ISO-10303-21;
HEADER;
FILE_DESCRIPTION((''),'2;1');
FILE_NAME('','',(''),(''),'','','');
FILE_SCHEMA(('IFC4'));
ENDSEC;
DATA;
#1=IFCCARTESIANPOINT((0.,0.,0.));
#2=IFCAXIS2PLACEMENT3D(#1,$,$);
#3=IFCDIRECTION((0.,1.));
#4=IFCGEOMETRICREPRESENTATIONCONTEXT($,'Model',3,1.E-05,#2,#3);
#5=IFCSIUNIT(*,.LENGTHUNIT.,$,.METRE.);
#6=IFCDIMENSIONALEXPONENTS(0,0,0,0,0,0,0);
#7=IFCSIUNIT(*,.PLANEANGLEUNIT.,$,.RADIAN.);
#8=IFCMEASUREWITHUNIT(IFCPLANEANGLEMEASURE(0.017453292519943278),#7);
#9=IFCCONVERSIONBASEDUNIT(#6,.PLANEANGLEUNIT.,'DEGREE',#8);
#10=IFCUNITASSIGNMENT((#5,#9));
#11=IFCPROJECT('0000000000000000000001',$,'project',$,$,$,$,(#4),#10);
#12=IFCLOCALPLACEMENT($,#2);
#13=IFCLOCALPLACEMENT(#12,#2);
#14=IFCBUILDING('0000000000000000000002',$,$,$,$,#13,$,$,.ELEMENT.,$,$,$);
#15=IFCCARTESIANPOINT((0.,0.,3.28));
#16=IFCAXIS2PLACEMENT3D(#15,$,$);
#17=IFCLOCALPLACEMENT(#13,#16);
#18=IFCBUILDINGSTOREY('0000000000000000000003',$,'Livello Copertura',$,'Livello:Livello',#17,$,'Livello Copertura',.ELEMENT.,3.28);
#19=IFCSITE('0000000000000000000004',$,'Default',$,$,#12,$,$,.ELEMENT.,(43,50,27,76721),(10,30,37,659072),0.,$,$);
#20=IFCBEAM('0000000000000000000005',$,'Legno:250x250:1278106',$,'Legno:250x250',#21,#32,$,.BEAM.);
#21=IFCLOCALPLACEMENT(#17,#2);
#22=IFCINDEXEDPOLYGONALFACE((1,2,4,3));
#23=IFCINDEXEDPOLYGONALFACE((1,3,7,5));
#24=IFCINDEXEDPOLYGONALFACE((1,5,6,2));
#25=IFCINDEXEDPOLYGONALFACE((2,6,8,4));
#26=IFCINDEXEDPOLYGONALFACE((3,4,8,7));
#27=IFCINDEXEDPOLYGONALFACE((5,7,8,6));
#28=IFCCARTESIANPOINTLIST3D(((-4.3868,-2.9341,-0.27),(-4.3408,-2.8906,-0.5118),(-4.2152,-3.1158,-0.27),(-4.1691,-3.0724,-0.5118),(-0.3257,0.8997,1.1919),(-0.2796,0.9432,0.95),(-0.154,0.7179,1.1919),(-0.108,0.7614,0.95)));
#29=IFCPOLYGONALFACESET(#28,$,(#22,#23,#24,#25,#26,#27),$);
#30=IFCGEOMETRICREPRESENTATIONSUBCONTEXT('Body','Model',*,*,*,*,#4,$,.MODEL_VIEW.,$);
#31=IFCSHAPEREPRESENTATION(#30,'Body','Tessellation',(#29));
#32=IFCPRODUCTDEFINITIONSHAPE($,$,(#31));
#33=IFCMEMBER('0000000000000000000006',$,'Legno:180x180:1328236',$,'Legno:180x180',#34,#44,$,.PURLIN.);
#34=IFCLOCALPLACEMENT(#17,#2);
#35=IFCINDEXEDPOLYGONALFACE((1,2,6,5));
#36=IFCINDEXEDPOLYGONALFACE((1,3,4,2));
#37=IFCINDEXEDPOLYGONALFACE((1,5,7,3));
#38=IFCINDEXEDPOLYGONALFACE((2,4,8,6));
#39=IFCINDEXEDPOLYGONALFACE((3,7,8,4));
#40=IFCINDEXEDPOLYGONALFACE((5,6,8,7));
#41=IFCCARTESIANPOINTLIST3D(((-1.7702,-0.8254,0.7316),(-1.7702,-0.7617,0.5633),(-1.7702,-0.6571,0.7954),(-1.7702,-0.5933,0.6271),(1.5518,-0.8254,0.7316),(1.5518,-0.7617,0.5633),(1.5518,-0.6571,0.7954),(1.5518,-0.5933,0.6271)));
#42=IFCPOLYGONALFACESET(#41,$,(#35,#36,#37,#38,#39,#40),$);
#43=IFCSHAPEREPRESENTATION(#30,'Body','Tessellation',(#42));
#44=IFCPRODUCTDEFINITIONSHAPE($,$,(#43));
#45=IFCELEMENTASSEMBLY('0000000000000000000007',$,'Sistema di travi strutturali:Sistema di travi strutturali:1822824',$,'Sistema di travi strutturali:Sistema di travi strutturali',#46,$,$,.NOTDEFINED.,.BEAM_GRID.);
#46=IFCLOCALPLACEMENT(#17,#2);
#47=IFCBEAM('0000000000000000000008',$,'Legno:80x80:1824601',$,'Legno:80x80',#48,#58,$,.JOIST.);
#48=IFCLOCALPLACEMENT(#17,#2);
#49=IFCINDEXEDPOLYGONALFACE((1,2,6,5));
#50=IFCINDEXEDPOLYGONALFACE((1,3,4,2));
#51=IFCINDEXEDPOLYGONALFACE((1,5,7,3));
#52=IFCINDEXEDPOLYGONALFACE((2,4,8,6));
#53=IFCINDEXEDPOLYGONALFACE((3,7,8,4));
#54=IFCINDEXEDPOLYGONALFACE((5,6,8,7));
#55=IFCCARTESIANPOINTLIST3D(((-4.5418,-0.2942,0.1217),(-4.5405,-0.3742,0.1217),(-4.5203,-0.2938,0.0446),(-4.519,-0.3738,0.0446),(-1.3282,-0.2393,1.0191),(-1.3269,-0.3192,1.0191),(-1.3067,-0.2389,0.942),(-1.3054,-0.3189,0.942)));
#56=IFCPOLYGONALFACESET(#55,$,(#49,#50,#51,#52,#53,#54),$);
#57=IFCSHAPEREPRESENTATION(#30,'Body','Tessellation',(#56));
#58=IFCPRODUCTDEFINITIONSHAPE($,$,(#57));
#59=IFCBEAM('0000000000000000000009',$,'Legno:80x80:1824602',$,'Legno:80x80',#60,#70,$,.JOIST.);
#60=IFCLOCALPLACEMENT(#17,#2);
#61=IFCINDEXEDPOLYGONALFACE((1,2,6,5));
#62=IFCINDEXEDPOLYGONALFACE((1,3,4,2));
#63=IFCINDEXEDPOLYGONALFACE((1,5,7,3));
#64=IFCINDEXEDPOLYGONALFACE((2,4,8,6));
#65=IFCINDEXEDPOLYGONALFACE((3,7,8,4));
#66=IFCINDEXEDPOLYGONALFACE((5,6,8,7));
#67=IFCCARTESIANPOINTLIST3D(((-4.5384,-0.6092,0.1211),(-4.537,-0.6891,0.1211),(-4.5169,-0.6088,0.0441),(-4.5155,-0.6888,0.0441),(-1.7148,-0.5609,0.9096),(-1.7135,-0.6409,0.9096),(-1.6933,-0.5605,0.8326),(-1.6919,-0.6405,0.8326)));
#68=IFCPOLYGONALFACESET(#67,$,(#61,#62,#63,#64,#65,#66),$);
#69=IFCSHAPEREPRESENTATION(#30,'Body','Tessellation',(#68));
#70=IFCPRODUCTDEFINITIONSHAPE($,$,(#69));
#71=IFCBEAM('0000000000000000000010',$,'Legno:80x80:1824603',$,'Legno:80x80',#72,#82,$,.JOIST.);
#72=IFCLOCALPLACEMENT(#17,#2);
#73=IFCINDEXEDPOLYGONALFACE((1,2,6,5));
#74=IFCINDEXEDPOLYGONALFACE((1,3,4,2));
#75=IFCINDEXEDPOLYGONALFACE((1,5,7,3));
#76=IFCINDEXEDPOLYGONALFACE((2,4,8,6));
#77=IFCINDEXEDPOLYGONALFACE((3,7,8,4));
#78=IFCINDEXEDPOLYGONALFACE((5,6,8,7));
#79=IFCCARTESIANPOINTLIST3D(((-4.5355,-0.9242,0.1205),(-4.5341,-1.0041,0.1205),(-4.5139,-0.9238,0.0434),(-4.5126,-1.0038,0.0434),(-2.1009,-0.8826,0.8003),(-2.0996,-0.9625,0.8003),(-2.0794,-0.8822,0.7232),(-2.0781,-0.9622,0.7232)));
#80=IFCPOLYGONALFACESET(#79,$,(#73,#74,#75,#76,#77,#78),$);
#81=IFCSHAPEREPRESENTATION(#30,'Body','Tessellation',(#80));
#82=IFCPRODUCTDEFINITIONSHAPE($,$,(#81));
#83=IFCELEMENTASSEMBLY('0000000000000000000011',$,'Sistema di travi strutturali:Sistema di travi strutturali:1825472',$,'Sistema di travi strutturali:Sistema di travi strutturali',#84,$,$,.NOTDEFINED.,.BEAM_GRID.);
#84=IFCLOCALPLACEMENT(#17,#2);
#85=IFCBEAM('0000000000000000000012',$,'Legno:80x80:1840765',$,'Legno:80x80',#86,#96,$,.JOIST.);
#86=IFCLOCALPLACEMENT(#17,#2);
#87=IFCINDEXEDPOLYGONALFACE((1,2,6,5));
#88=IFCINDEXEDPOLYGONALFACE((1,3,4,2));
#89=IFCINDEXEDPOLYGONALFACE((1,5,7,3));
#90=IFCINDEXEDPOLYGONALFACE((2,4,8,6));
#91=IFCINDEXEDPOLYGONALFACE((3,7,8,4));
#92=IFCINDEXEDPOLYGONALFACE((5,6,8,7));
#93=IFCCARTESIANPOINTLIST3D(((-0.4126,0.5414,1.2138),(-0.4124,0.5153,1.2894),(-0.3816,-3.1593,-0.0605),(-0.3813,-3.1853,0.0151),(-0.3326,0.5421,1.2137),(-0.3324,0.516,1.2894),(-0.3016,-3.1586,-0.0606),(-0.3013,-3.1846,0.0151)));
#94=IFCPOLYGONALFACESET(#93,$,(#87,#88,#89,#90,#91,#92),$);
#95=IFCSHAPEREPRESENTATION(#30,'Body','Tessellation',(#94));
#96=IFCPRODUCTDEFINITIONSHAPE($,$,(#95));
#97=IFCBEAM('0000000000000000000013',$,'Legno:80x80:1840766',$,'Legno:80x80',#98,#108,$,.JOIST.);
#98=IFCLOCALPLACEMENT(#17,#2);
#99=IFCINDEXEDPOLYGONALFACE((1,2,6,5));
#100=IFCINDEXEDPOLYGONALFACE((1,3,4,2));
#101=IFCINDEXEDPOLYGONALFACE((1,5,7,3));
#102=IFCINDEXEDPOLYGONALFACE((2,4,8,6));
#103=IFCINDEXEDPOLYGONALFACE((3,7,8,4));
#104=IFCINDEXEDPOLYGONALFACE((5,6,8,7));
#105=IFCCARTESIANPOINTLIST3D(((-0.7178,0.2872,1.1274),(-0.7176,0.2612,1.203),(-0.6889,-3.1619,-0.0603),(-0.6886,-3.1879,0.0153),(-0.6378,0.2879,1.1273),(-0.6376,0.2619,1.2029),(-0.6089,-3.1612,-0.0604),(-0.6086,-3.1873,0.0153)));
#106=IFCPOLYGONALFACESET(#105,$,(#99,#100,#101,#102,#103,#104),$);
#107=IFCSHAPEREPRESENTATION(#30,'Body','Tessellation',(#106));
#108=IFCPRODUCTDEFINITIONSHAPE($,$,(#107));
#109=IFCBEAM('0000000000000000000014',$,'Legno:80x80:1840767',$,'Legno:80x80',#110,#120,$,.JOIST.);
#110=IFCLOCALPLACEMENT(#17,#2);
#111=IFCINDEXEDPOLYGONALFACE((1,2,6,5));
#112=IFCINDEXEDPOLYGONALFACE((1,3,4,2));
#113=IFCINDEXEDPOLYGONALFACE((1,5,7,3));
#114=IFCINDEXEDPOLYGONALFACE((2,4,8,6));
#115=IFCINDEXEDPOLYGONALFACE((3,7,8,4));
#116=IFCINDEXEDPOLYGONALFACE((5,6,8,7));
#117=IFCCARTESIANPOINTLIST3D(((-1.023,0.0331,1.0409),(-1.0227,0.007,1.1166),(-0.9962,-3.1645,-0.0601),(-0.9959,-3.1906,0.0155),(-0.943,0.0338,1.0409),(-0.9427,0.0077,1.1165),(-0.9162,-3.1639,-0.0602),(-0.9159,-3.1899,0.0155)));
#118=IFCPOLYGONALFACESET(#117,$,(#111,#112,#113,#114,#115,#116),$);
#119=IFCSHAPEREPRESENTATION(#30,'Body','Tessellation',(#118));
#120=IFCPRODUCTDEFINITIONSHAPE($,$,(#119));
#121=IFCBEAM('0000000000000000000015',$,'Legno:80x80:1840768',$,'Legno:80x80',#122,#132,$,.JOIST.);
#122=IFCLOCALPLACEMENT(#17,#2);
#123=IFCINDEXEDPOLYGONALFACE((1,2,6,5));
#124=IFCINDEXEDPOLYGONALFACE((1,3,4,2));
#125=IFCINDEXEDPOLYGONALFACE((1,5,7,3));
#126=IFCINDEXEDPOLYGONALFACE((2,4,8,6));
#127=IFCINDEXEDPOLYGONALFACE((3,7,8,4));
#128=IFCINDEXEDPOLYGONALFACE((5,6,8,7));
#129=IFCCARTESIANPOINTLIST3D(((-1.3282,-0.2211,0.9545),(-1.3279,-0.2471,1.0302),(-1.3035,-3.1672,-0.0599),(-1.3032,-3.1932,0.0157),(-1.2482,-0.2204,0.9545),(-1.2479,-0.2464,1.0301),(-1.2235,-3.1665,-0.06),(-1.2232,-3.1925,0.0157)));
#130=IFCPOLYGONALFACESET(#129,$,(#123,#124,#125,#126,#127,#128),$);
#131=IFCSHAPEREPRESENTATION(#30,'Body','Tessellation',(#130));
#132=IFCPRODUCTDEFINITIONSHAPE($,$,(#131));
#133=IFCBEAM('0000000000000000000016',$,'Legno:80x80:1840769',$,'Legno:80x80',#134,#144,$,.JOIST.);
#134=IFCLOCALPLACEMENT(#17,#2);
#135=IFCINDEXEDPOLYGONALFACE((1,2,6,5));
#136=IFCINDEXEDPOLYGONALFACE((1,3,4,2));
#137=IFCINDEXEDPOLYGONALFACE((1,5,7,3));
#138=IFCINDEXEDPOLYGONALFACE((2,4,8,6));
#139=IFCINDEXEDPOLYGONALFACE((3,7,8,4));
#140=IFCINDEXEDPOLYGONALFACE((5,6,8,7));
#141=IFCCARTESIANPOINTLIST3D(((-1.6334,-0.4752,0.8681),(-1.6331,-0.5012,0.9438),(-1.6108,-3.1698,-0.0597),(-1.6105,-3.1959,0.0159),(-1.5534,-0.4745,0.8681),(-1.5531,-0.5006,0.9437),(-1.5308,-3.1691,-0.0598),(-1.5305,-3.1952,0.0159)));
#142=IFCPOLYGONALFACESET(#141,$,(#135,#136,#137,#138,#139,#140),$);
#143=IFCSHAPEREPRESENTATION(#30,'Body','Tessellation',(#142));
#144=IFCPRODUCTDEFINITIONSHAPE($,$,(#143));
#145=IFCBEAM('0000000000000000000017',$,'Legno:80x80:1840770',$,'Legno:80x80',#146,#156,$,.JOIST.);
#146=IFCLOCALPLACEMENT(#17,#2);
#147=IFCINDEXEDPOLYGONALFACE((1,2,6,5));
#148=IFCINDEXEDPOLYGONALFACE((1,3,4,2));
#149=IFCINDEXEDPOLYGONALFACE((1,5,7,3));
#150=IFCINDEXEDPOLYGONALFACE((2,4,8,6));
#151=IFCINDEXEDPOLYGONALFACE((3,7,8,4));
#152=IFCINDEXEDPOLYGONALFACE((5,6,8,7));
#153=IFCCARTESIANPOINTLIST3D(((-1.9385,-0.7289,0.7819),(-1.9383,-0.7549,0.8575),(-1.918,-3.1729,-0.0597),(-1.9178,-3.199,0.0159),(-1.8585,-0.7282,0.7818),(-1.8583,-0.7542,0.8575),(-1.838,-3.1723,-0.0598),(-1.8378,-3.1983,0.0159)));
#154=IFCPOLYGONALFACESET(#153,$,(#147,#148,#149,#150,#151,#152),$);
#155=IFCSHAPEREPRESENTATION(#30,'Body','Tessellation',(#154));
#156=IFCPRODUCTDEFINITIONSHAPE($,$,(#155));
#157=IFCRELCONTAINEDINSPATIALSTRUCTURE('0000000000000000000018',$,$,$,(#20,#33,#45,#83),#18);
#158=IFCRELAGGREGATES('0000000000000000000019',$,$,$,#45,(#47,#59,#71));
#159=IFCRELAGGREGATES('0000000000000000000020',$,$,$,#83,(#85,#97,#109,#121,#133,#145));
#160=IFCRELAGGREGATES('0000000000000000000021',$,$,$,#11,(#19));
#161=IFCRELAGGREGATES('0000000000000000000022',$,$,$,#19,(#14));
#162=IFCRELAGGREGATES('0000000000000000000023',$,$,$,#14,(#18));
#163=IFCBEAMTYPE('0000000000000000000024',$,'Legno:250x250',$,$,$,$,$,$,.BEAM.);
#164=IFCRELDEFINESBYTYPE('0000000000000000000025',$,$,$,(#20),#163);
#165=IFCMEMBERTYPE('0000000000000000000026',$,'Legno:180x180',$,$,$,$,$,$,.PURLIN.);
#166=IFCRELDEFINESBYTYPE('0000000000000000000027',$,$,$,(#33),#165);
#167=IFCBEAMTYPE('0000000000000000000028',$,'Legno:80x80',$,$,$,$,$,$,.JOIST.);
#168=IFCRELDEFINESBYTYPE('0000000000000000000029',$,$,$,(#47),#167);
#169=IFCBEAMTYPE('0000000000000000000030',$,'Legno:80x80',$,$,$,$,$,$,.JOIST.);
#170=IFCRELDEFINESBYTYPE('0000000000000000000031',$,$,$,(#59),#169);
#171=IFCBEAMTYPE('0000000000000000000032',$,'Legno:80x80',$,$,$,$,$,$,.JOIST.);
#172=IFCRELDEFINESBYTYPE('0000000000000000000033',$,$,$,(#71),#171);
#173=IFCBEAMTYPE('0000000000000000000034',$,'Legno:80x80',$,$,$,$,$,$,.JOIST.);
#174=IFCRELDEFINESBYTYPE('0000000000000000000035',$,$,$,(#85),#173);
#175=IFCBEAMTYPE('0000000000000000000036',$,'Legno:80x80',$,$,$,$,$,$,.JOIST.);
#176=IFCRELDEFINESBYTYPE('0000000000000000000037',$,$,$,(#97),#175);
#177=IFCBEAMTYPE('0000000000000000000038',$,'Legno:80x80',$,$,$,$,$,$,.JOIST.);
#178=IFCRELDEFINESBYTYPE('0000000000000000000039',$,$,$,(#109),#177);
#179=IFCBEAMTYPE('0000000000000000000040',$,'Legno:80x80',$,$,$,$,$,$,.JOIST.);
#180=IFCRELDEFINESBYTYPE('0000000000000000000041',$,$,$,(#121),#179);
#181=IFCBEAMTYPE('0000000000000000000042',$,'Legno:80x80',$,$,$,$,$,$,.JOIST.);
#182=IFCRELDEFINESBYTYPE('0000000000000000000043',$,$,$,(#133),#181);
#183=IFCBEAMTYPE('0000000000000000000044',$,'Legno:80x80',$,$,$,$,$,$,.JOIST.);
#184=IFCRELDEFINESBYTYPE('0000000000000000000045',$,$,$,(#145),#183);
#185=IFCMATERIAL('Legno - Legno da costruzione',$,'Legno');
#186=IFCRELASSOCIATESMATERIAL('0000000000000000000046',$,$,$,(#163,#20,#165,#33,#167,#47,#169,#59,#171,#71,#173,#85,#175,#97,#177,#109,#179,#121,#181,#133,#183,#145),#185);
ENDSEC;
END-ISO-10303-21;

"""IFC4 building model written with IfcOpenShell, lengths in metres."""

from ifc_helpers import new_model, entity, si_unit, converted_unit, direction, frame, origin, place, context, subcontext, project, spatial, indexed_curve, outline, extrude, source, transform, mapped, material, type_object, type_shapes, element, aggregate, save


model = new_model("IFC4")

# Units and contexts
model_context = context("Model", 3, precision=1e-05, world=origin(), true_north=direction((0.0, 1.0)))
body_context = subcontext(model_context, "Body", "Model", "MODEL_VIEW")
ifc_project = project(units=[si_unit("LENGTHUNIT", "METRE"), converted_unit("PLANEANGLEUNIT", "DEGREE", entity("IfcPlaneAngleMeasure", 0.017453292519943278), si_unit("PLANEANGLEUNIT", "RADIAN"), dimensions=[0, 0, 0, 0, 0, 0, 0])], contexts=[model_context])

# Site, building, storey
site_placement = place(None, origin())
site = spatial("IfcSite", under=ifc_project, at=site_placement, Name="Default", CompositionType="ELEMENT", RefLatitude=(43, 50, 27, 76721), RefLongitude=(10, 30, 37, 659072), RefElevation=0.0)
building_placement = place(site_placement, origin())
building = spatial("IfcBuilding", under=site, at=building_placement, CompositionType="ELEMENT")
storey_placement = place(building_placement, frame((0.0, 0.0, 3.28)))
storey = spatial("IfcBuildingStorey", under=building, at=storey_placement, Name="Livello Copertura", ObjectType="Livello:Livello", LongName="Livello Copertura", CompositionType="ELEMENT", Elevation=3.28)

# Beam
ifc_material = material(Name="Legno - Legno da costruzione", Category="Legno")
beam_type_1 = type_object("IfcBeamType", Name="Legno:250x250", PredefinedType="BEAM", material=ifc_material)
shared_shape_1 = source(origin(), body_context, "Body", "SweptSolid", [
    extrude(outline(indexed_curve([(-2.8865, -0.125), (2.8865, -0.125), (2.8865, 0.125), (-2.8865, 0.125), (-2.8865, -0.125)], self_intersect=False)), frame((-0.093, 0.0, -0.125), z_axis=(0.0, 0.0, 1.0), x_axis=(-1.0, 0.0, 0.0)), (0.0, 0.0, 1.0), 0.25),
])
type_shapes(beam_type_1, [shared_shape_1])
beam_1_placement = place(storey_placement, frame((-2.182, -1.0246, 0.3636), z_axis=(-0.18413, -0.173822, 0.96741), x_axis=(0.703469, 0.664088, 0.253215)))
element("IfcBeam", 1, at=beam_1_placement, inside=storey, type_object=beam_type_1, material=ifc_material, Name="Legno:250x250:1278106", ObjectType="Legno:250x250", PredefinedType="BEAM", context=body_context, shape_type="MappedRepresentation", body=[
    mapped(shared_shape_1, transform((0.0, 0.0, 0.0), scale=1.0)),
])

# Member
member_type = type_object("IfcMemberType", Name="Legno:180x180", PredefinedType="PURLIN", material=ifc_material)
shared_shape_2 = source(origin(), body_context, "Body", "SweptSolid", [
    extrude(outline(indexed_curve([(-1.661, -0.09), (1.661, -0.09), (1.661, 0.09), (-1.661, 0.09), (-1.661, -0.09)], self_intersect=False)), frame((0.0, 0.0, -0.09), z_axis=(0.0, 0.0, 1.0), x_axis=(-1.0, 0.0, 0.0)), (0.0, 0.0, 1.0), 0.18),
])
type_shapes(member_type, [shared_shape_2])
member_placement = place(storey_placement, frame((-0.1092, -0.7094, 0.6793), z_axis=(0.0, -0.354291, 0.935135), x_axis=(1.0, 0.0, 0.0)))
element("IfcMember", 2, at=member_placement, inside=storey, type_object=member_type, material=ifc_material, Name="Legno:180x180:1328236", ObjectType="Legno:180x180", PredefinedType="PURLIN", context=body_context, shape_type="MappedRepresentation", body=[
    mapped(shared_shape_2, transform((0.0, 0.0, 0.0), scale=1.0)),
])

# Element assemblies, beams
assembly_1_placement = place(storey_placement, origin())
assembly_1 = element("IfcElementAssembly", 3, at=assembly_1_placement, inside=storey, Name="Sistema di travi strutturali:Sistema di travi strutturali:1822824", ObjectType="Sistema di travi strutturali:Sistema di travi strutturali", AssemblyPlace="NOTDEFINED", PredefinedType="BEAM_GRID")
beam_type_2 = type_object("IfcBeamType", Name="Legno:80x80", PredefinedType="JOIST", material=ifc_material)
shared_shape_3 = source(origin(), body_context, "Body", "SweptSolid", [
    extrude(outline(indexed_curve([(-1.6685, -0.04), (1.6685, -0.04), (1.6685, 0.04), (-1.6685, 0.04), (-1.6685, -0.04)], self_intersect=False)), frame((0.0, 0.0, -0.04), z_axis=(0.0, 0.0, 1.0), x_axis=(-1.0, 0.0, 0.0)), (0.0, 0.0, 1.0), 0.08),
])
type_shapes(beam_type_2, [shared_shape_3])
beam_2_placement = place(assembly_1_placement, frame((-2.9236, -0.3065, 0.5319), z_axis=(-0.268881, -0.004594, 0.963163), x_axis=(0.963022, 0.016456, 0.26892)))
beam_2 = element("IfcBeam", 4, at=beam_2_placement, type_object=beam_type_2, material=ifc_material, Name="Legno:80x80:1824601", ObjectType="Legno:80x80", PredefinedType="JOIST", context=body_context, shape_type="MappedRepresentation", body=[
    mapped(shared_shape_3, transform((0.0, 0.0, 0.0), scale=1.0)),
])
beam_type_3 = type_object("IfcBeamType", Name="Legno:80x80", PredefinedType="JOIST", material=ifc_material)
shared_shape_4 = source(origin(), body_context, "Body", "SweptSolid", [
    extrude(outline(indexed_curve([(-1.466, -0.04), (1.466, -0.04), (1.466, 0.04), (-1.466, 0.04), (-1.466, -0.04)], self_intersect=False)), frame((0.0, 0.0, -0.04), z_axis=(0.0, 0.0, 1.0), x_axis=(-1.0, 0.0, 0.0)), (0.0, 0.0, 1.0), 0.08),
])
type_shapes(beam_type_3, [shared_shape_4])
beam_3_placement = place(assembly_1_placement, frame((-3.1152, -0.6248, 0.4769), z_axis=(-0.268881, -0.004594, 0.963163), x_axis=(0.963022, 0.016456, 0.26892)))
beam_3 = element("IfcBeam", 5, at=beam_3_placement, type_object=beam_type_3, material=ifc_material, Name="Legno:80x80:1824602", ObjectType="Legno:80x80", PredefinedType="JOIST", context=body_context, shape_type="MappedRepresentation", body=[
    mapped(shared_shape_4, transform((0.0, 0.0, 0.0), scale=1.0)),
])
beam_type_4 = type_object("IfcBeamType", Name="Legno:80x80", PredefinedType="JOIST", material=ifc_material)
shared_shape_5 = source(origin(), body_context, "Body", "SweptSolid", [
    extrude(outline(indexed_curve([(-1.264, -0.04), (1.264, -0.04), (1.264, 0.04), (-1.264, 0.04), (-1.264, -0.04)], self_intersect=False)), frame((0.0, 0.0, -0.04), z_axis=(0.0, 0.0, 1.0), x_axis=(-1.0, 0.0, 0.0)), (0.0, 0.0, 1.0), 0.08),
])
type_shapes(beam_type_4, [shared_shape_5])
beam_4_placement = place(assembly_1_placement, frame((-3.3068, -0.9432, 0.4219), z_axis=(-0.268881, -0.004594, 0.963163), x_axis=(0.963022, 0.016456, 0.26892)))
beam_4 = element("IfcBeam", 6, at=beam_4_placement, type_object=beam_type_4, material=ifc_material, Name="Legno:80x80:1824603", ObjectType="Legno:80x80", PredefinedType="JOIST", context=body_context, shape_type="MappedRepresentation", body=[
    mapped(shared_shape_5, transform((0.0, 0.0, 0.0), scale=1.0)),
])
aggregate(assembly_1, [beam_2, beam_3, beam_4])
assembly_2_placement = place(storey_placement, origin())
assembly_2 = element("IfcElementAssembly", 7, at=assembly_2_placement, inside=storey, Name="Sistema di travi strutturali:Sistema di travi strutturali:1825472", ObjectType="Sistema di travi strutturali:Sistema di travi strutturali", AssemblyPlace="NOTDEFINED", PredefinedType="BEAM_GRID")
beam_type_5 = type_object("IfcBeamType", Name="Legno:80x80", PredefinedType="JOIST", material=ifc_material)
shared_shape_6 = source(origin(), body_context, "Body", "SweptSolid", [
    extrude(outline(indexed_curve([(-1.957, -0.04), (1.957, -0.04), (1.957, 0.04), (-1.957, 0.04), (-1.957, -0.04)], self_intersect=False)), frame((0.0, 0.0, -0.04), z_axis=(0.0, 0.0, 1.0), x_axis=(-1.0, 0.0, 0.0)), (0.0, 0.0, 1.0), 0.08),
])
type_shapes(beam_type_5, [shared_shape_6])
beam_5_placement = place(assembly_2_placement, frame((-0.357, -1.3216, 0.6144), z_axis=(0.003393, -0.32555, 0.945519), x_axis=(-0.007932, 0.945486, 0.325568)))
beam_5 = element("IfcBeam", 8, at=beam_5_placement, type_object=beam_type_5, material=ifc_material, Name="Legno:80x80:1840765", ObjectType="Legno:80x80", PredefinedType="JOIST", context=body_context, shape_type="MappedRepresentation", body=[
    mapped(shared_shape_6, transform((0.0, 0.0, 0.0), scale=1.0)),
])
beam_type_6 = type_object("IfcBeamType", Name="Legno:80x80", PredefinedType="JOIST", material=ifc_material)
shared_shape_7 = source(origin(), body_context, "Body", "SweptSolid", [
    extrude(outline(indexed_curve([(-1.824, -0.04), (1.824, -0.04), (1.824, 0.04), (-1.824, 0.04), (-1.824, -0.04)], self_intersect=False)), frame((0.0, 0.0, -0.04), z_axis=(0.0, 0.0, 1.0), x_axis=(-1.0, 0.0, 0.0)), (0.0, 0.0, 1.0), 0.08),
])
type_shapes(beam_type_6, [shared_shape_7])
beam_6_placement = place(assembly_2_placement, frame((-0.6632, -1.45, 0.5713), z_axis=(0.003393, -0.32555, 0.945519), x_axis=(-0.007932, 0.945486, 0.325568)))
beam_6 = element("IfcBeam", 9, at=beam_6_placement, type_object=beam_type_6, material=ifc_material, Name="Legno:80x80:1840766", ObjectType="Legno:80x80", PredefinedType="JOIST", context=body_context, shape_type="MappedRepresentation", body=[
    mapped(shared_shape_7, transform((0.0, 0.0, 0.0), scale=1.0)),
])
beam_type_7 = type_object("IfcBeamType", Name="Legno:80x80", PredefinedType="JOIST", material=ifc_material)
shared_shape_8 = source(origin(), body_context, "Body", "SweptSolid", [
    extrude(outline(indexed_curve([(-1.691, -0.04), (1.691, -0.04), (1.691, 0.04), (-1.691, 0.04), (-1.691, -0.04)], self_intersect=False)), frame((0.0, 0.0, -0.04), z_axis=(0.0, 0.0, 1.0), x_axis=(-1.0, 0.0, 0.0)), (0.0, 0.0, 1.0), 0.08),
])
type_shapes(beam_type_7, [shared_shape_8])
beam_7_placement = place(assembly_2_placement, frame((-0.9695, -1.5784, 0.5282), z_axis=(0.003393, -0.32555, 0.945519), x_axis=(-0.007932, 0.945486, 0.325568)))
beam_7 = element("IfcBeam", 10, at=beam_7_placement, type_object=beam_type_7, material=ifc_material, Name="Legno:80x80:1840767", ObjectType="Legno:80x80", PredefinedType="JOIST", context=body_context, shape_type="MappedRepresentation", body=[
    mapped(shared_shape_8, transform((0.0, 0.0, 0.0), scale=1.0)),
])
beam_type_8 = type_object("IfcBeamType", Name="Legno:80x80", PredefinedType="JOIST", material=ifc_material)
shared_shape_9 = source(origin(), body_context, "Body", "SweptSolid", [
    extrude(outline(indexed_curve([(-1.558, -0.04), (1.558, -0.04), (1.558, 0.04), (-1.558, 0.04), (-1.558, -0.04)], self_intersect=False)), frame((0.0, 0.0, -0.04), z_axis=(0.0, 0.0, 1.0), x_axis=(-1.0, 0.0, 0.0)), (0.0, 0.0, 1.0), 0.08),
])
type_shapes(beam_type_8, [shared_shape_9])
beam_8_placement = place(assembly_2_placement, frame((-1.2757, -1.7068, 0.4851), z_axis=(0.003393, -0.32555, 0.945519), x_axis=(-0.007932, 0.945486, 0.325568)))
beam_8 = element("IfcBeam", 11, at=beam_8_placement, type_object=beam_type_8, material=ifc_material, Name="Legno:80x80:1840768", ObjectType="Legno:80x80", PredefinedType="JOIST", context=body_context, shape_type="MappedRepresentation", body=[
    mapped(shared_shape_9, transform((0.0, 0.0, 0.0), scale=1.0)),
])
beam_type_9 = type_object("IfcBeamType", Name="Legno:80x80", PredefinedType="JOIST", material=ifc_material)
shared_shape_10 = source(origin(), body_context, "Body", "SweptSolid", [
    extrude(outline(indexed_curve([(-1.425, -0.04), (1.425, -0.04), (1.425, 0.04), (-1.425, 0.04), (-1.425, -0.04)], self_intersect=False)), frame((0.0, 0.0, -0.04), z_axis=(0.0, 0.0, 1.0), x_axis=(-1.0, 0.0, 0.0)), (0.0, 0.0, 1.0), 0.08),
])
type_shapes(beam_type_9, [shared_shape_10])
beam_9_placement = place(assembly_2_placement, frame((-1.5819, -1.8352, 0.442), z_axis=(0.003393, -0.32555, 0.945519), x_axis=(-0.007932, 0.945486, 0.325568)))
beam_9 = element("IfcBeam", 12, at=beam_9_placement, type_object=beam_type_9, material=ifc_material, Name="Legno:80x80:1840769", ObjectType="Legno:80x80", PredefinedType="JOIST", context=body_context, shape_type="MappedRepresentation", body=[
    mapped(shared_shape_10, transform((0.0, 0.0, 0.0), scale=1.0)),
])
beam_type_10 = type_object("IfcBeamType", Name="Legno:80x80", PredefinedType="JOIST", material=ifc_material)
shared_shape_11 = source(origin(), body_context, "Body", "SweptSolid", [
    extrude(outline(indexed_curve([(-1.2925, -0.04), (1.2925, -0.04), (1.2925, 0.04), (-1.2925, 0.04), (-1.2925, -0.04)], self_intersect=False)), frame((0.0, 0.0, -0.04), z_axis=(0.0, 0.0, 1.0), x_axis=(-1.0, 0.0, 0.0)), (0.0, 0.0, 1.0), 0.08),
])
type_shapes(beam_type_10, [shared_shape_11])
beam_10_placement = place(assembly_2_placement, frame((-1.8882, -1.9636, 0.3989), z_axis=(0.003393, -0.32555, 0.945519), x_axis=(-0.007932, 0.945486, 0.325568)))
beam_10 = element("IfcBeam", 13, at=beam_10_placement, type_object=beam_type_10, material=ifc_material, Name="Legno:80x80:1840770", ObjectType="Legno:80x80", PredefinedType="JOIST", context=body_context, shape_type="MappedRepresentation", body=[
    mapped(shared_shape_11, transform((0.0, 0.0, 0.0), scale=1.0)),
])
aggregate(assembly_2, [beam_5, beam_6, beam_7, beam_8, beam_9, beam_10])

save(model, "model.ifc")
